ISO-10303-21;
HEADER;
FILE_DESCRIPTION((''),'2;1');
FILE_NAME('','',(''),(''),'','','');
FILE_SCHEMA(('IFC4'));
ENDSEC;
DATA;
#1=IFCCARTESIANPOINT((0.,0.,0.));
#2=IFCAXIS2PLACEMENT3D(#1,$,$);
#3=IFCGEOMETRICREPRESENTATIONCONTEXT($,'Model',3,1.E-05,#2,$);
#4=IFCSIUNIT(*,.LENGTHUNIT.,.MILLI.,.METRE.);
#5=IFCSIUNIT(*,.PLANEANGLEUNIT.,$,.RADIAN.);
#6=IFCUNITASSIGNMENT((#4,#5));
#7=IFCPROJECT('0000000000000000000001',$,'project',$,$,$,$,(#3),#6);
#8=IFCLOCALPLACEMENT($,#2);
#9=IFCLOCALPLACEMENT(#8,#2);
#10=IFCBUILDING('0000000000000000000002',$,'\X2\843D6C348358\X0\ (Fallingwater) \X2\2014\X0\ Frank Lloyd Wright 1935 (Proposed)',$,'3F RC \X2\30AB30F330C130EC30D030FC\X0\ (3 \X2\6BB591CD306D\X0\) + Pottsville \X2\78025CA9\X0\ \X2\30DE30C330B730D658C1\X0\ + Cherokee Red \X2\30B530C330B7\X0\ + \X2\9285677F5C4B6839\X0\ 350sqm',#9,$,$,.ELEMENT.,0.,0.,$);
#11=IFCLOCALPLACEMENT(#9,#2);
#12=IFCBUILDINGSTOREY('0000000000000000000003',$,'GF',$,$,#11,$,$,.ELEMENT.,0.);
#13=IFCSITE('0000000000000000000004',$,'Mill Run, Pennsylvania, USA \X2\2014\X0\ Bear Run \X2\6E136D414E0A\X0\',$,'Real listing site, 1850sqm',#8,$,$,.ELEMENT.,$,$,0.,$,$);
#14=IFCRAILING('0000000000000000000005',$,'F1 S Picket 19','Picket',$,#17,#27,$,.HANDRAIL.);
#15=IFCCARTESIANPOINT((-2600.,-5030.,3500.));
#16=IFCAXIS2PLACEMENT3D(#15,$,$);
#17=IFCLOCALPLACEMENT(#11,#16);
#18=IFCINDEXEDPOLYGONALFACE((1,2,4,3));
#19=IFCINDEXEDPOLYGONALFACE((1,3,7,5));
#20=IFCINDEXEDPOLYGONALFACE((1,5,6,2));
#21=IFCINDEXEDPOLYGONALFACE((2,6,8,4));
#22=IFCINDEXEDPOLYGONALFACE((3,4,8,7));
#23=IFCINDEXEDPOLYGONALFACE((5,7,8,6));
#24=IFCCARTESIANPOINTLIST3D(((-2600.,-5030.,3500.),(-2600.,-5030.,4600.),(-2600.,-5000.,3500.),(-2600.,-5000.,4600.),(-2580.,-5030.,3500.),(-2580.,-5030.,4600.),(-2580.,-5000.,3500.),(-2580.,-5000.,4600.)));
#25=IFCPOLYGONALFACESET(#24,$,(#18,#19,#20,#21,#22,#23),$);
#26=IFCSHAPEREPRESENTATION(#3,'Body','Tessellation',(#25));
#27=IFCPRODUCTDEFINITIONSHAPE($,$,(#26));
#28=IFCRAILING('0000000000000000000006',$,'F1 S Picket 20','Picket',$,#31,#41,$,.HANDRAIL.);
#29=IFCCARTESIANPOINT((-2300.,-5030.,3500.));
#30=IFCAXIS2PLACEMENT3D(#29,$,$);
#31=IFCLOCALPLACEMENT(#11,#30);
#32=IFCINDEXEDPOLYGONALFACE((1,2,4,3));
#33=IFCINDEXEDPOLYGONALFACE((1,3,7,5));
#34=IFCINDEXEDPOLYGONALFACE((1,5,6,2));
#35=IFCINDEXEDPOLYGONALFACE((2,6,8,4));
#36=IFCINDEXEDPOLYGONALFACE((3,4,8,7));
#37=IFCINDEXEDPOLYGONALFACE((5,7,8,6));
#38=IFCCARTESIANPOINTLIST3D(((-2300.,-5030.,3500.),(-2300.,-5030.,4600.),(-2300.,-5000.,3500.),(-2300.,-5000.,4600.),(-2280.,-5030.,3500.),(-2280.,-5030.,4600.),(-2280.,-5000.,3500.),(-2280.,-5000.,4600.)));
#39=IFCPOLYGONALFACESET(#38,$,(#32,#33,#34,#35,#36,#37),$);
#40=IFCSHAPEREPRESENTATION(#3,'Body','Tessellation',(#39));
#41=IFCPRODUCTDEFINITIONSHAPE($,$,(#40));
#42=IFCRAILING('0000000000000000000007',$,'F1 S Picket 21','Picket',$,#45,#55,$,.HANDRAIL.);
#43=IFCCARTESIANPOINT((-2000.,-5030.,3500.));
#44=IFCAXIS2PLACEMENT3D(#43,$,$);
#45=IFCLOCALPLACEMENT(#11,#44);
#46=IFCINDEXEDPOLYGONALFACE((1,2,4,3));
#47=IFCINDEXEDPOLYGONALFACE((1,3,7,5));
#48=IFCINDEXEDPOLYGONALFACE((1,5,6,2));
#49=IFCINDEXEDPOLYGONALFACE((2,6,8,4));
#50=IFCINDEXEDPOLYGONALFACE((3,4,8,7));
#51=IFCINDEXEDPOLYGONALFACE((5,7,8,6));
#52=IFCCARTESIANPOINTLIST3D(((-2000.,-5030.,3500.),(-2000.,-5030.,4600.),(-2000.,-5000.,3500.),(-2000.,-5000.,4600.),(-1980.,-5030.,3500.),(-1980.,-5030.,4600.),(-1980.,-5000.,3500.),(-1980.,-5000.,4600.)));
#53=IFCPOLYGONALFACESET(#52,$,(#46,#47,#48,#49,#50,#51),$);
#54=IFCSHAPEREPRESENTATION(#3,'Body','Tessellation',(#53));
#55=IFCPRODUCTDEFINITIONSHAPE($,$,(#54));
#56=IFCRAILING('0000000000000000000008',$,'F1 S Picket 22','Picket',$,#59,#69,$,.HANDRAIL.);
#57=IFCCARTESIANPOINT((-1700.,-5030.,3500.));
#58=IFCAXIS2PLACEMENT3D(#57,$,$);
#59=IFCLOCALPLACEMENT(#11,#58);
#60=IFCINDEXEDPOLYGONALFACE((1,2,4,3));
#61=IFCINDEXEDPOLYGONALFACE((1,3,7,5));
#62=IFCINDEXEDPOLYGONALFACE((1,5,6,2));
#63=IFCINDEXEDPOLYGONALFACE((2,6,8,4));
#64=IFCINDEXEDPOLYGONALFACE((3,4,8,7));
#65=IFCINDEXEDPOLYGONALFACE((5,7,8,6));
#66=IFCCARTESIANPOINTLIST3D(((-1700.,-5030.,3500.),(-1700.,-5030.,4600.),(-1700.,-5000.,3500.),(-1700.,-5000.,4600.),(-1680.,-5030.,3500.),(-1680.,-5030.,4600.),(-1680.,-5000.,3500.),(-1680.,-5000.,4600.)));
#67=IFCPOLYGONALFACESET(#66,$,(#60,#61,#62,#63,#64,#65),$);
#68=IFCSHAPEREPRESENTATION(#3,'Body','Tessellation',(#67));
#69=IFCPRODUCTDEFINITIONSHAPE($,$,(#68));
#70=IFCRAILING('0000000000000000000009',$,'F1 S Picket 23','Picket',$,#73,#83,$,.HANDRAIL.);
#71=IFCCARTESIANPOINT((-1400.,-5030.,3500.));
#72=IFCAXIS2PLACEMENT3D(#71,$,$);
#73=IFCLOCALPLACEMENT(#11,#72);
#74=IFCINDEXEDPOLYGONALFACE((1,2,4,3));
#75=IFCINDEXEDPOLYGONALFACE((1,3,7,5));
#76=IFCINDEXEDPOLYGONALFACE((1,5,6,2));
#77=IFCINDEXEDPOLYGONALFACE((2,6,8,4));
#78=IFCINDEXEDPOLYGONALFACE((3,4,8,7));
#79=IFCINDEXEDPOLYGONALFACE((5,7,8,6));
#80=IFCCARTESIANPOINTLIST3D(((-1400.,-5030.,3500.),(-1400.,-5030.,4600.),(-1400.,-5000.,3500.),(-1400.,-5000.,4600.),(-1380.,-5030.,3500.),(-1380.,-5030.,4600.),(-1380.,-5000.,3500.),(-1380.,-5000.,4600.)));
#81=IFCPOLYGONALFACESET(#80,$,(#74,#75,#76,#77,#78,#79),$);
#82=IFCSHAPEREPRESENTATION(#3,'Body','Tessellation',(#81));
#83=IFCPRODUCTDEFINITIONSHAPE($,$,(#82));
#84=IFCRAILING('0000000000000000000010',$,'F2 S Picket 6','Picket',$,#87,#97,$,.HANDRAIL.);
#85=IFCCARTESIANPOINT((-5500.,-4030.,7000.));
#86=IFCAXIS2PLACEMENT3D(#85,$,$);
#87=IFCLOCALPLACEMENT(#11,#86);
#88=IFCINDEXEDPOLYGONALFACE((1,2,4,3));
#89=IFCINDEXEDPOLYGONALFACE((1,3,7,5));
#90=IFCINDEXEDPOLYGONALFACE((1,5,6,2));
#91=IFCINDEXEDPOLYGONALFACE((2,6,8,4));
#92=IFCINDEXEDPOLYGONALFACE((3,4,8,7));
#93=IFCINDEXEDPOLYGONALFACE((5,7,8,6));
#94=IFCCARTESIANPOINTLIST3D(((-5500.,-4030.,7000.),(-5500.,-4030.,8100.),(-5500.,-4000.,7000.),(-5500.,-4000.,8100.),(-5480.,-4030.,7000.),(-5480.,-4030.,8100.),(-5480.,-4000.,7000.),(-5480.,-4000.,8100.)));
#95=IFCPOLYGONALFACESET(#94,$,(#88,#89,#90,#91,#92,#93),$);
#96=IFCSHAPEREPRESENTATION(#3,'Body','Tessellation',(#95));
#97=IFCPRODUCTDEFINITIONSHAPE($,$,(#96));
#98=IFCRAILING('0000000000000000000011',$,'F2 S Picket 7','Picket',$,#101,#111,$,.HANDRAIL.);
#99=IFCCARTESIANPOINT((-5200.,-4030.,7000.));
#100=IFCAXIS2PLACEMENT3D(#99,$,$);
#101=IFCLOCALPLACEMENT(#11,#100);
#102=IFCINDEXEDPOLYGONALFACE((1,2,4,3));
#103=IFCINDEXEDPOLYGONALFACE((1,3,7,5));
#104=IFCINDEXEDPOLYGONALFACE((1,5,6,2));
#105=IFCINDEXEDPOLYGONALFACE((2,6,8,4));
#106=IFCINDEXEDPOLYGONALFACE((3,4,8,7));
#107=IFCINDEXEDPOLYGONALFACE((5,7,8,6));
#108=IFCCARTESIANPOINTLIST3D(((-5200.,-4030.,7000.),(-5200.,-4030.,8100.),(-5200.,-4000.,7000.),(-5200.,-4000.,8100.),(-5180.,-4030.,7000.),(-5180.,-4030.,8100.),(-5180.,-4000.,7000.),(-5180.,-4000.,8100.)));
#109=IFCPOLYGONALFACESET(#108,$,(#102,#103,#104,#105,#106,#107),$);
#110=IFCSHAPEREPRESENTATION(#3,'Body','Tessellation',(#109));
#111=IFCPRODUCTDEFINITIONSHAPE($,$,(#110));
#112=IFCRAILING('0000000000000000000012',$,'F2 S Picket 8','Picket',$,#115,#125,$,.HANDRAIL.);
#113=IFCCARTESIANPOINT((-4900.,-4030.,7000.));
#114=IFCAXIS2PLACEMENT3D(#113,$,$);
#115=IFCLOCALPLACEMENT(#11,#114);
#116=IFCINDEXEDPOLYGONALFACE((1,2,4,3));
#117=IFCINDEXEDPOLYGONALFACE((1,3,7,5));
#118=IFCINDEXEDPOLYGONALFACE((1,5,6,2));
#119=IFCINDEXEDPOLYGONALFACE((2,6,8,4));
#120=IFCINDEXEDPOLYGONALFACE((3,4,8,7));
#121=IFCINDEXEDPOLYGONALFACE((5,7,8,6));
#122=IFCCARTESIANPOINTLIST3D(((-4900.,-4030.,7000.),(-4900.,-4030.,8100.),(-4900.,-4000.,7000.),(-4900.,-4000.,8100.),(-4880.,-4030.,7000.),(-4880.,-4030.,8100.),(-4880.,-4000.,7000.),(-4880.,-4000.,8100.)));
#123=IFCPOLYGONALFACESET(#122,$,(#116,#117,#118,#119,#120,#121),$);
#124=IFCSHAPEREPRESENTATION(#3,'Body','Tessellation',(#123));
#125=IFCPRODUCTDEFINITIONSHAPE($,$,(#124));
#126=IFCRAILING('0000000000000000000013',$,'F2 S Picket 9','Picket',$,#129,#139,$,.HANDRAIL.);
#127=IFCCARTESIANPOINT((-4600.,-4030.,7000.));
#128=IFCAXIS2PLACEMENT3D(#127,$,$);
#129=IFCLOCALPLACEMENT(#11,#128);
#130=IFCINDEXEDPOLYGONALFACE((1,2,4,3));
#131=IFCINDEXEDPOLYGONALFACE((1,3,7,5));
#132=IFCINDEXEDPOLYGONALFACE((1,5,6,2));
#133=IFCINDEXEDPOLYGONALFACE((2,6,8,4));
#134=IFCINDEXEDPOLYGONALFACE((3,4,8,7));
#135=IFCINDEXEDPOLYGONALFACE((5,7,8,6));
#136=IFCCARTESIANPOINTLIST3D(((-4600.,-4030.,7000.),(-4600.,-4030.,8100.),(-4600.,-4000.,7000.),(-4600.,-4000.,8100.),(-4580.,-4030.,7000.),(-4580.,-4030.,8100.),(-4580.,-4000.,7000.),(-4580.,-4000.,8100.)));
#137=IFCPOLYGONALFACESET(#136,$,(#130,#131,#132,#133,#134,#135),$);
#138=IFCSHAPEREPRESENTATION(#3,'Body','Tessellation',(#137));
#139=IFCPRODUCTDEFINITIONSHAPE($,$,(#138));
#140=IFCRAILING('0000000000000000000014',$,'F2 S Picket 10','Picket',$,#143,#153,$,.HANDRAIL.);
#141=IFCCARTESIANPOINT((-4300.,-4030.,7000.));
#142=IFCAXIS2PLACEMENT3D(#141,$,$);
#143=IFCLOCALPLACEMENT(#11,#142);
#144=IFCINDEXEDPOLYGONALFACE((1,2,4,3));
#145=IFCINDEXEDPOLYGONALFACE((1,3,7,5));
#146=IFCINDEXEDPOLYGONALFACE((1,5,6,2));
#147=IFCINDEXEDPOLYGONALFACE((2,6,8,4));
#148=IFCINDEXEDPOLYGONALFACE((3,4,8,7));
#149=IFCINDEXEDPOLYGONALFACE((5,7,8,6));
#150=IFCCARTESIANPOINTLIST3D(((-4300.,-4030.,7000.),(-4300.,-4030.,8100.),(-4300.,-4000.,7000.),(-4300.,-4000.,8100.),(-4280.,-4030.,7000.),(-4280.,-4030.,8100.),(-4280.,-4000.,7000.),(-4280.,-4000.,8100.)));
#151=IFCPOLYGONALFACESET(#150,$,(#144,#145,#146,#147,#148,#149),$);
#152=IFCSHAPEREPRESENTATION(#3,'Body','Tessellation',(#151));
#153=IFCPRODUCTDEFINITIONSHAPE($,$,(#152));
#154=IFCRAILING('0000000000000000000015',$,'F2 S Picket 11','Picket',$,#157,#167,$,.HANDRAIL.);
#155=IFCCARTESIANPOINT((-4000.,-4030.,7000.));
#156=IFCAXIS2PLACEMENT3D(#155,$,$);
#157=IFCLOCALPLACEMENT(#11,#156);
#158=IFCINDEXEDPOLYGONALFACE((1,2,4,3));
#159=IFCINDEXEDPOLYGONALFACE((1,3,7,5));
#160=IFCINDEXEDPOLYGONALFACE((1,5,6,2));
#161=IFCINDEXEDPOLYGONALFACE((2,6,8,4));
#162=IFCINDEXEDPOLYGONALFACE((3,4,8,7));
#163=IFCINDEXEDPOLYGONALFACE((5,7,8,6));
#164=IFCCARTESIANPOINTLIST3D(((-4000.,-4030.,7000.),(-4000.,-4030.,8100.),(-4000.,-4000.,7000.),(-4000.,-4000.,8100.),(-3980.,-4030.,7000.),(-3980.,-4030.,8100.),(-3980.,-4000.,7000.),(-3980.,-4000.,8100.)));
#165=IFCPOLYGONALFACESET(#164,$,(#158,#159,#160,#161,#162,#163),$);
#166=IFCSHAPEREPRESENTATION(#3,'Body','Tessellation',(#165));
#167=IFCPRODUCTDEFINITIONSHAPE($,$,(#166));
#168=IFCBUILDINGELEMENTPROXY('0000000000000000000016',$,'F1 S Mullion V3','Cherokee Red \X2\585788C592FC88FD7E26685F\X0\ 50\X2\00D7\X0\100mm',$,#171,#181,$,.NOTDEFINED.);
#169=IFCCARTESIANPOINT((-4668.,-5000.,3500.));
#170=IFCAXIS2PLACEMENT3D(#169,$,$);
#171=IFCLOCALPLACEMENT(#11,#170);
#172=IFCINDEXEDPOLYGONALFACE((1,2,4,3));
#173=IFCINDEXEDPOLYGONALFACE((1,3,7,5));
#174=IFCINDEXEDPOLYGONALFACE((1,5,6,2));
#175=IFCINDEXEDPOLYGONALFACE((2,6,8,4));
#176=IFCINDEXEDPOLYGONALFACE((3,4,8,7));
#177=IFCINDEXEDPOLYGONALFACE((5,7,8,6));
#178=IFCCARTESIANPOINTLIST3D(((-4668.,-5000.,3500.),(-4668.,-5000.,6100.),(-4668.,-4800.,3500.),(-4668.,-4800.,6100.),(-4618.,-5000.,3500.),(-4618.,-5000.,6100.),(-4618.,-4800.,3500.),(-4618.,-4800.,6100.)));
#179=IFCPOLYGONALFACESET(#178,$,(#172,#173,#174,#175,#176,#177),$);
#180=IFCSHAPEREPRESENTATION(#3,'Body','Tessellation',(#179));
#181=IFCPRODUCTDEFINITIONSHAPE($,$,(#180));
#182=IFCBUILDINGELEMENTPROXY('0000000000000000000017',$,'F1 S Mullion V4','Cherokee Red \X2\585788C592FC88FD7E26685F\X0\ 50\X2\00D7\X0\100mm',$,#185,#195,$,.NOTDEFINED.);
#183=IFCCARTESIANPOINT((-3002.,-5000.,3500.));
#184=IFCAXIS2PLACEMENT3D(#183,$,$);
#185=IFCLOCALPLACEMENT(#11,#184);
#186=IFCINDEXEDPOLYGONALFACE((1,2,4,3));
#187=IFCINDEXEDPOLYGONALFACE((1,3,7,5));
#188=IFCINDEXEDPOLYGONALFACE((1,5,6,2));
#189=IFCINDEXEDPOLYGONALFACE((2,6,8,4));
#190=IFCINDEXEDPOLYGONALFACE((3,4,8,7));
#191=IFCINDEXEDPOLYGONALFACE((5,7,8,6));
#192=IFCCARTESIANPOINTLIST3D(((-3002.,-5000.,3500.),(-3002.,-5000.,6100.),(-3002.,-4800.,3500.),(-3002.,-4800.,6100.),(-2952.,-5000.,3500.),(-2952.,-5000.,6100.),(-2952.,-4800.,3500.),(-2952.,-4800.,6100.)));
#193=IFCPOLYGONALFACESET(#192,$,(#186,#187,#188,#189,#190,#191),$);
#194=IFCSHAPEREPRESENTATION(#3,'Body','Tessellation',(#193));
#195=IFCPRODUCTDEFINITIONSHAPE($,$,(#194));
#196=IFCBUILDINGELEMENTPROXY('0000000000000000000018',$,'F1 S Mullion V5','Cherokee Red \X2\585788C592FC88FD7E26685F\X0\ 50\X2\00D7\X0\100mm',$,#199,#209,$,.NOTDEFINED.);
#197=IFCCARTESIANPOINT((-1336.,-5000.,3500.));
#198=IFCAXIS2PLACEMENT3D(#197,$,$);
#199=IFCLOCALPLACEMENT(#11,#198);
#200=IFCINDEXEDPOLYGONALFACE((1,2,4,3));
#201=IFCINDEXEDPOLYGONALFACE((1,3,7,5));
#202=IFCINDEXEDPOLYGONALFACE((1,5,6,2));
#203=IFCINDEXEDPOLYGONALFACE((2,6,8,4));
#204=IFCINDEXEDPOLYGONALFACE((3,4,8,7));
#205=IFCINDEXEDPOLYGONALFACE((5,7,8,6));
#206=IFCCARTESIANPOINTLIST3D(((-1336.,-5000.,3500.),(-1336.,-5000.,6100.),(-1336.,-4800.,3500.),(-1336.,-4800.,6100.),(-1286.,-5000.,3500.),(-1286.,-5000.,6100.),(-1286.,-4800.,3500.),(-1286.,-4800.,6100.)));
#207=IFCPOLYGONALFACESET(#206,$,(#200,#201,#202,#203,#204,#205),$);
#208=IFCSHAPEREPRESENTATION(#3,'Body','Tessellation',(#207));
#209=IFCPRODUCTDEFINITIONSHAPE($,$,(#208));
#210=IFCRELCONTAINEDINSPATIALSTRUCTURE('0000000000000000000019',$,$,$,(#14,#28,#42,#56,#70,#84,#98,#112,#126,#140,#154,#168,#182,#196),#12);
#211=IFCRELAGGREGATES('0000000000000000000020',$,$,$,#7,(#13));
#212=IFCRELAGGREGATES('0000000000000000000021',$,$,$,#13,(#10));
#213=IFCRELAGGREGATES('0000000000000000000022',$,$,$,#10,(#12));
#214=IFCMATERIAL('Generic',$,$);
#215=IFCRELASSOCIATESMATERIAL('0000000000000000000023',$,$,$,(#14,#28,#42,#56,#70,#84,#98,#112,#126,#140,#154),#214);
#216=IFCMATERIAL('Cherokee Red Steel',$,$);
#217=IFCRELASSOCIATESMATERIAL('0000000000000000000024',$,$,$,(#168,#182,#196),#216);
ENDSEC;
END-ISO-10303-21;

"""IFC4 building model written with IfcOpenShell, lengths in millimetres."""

from ifc_helpers import new_model, si_unit, frame, frame_2d, origin, place, context, project, spatial, rectangle, extrude, material, element, save


model = new_model("IFC4")

# Units and contexts
model_context = context("Model", 3, precision=1e-05, world=origin())
ifc_project = project(units=[si_unit("LENGTHUNIT", "METRE", prefix="MILLI"), si_unit("PLANEANGLEUNIT", "RADIAN")], contexts=[model_context])

# Site, building, storey
site_placement = place(None, origin())
site = spatial("IfcSite", under=ifc_project, at=site_placement, Name="Mill Run, Pennsylvania, USA — Bear Run 渓流上", ObjectType="Real listing site, 1850sqm", CompositionType="ELEMENT", RefElevation=0.0)
building_placement = place(site_placement, origin())
building = spatial("IfcBuilding", under=site, at=building_placement, Name="落水荘 (Fallingwater) — Frank Lloyd Wright 1935 (Proposed)", ObjectType="3F RC カンチレバー (3 段重ね) + Pottsville 砂岩 マッシブ壁 + Cherokee Red サッシ + 銅板屋根 350sqm", CompositionType="ELEMENT", ElevationOfRefHeight=0.0, ElevationOfTerrain=0.0)
storey_placement = place(building_placement, origin())
storey = spatial("IfcBuildingStorey", under=building, at=storey_placement, Name="GF", CompositionType="ELEMENT", Elevation=0.0)

# Shared definitions
ifc_material_1 = material(Name="Cherokee Red Steel")

# Railings
ifc_material_2 = material(Name="Generic")
railing_1_placement = place(storey_placement, frame((-2600.0, -5030.0, 3500.0)))
element("IfcRailing", 1, at=railing_1_placement, inside=storey, material=ifc_material_2, Name="F1 S Picket 19", Description="Picket", PredefinedType="HANDRAIL", context=model_context, shape_type="SweptSolid", body=[
    extrude(rectangle(XDim=20.0, YDim=30.0, at=frame_2d((10.0, 15.0))), frame((-2600.0, -5030.0, 3500.0)), (0.0, 0.0, 1.0), 1100.0),
])
railing_2_placement = place(storey_placement, frame((-2300.0, -5030.0, 3500.0)))
element("IfcRailing", 2, at=railing_2_placement, inside=storey, material=ifc_material_2, Name="F1 S Picket 20", Description="Picket", PredefinedType="HANDRAIL", context=model_context, shape_type="SweptSolid", body=[
    extrude(rectangle(XDim=20.0, YDim=30.0, at=frame_2d((10.0, 15.0))), frame((-2300.0, -5030.0, 3500.0)), (0.0, 0.0, 1.0), 1100.0),
])
railing_3_placement = place(storey_placement, frame((-2000.0, -5030.0, 3500.0)))
element("IfcRailing", 3, at=railing_3_placement, inside=storey, material=ifc_material_2, Name="F1 S Picket 21", Description="Picket", PredefinedType="HANDRAIL", context=model_context, shape_type="SweptSolid", body=[
    extrude(rectangle(XDim=20.0, YDim=30.0, at=frame_2d((10.0, 15.0))), frame((-2000.0, -5030.0, 3500.0)), (0.0, 0.0, 1.0), 1100.0),
])
railing_4_placement = place(storey_placement, frame((-1700.0, -5030.0, 3500.0)))
element("IfcRailing", 4, at=railing_4_placement, inside=storey, material=ifc_material_2, Name="F1 S Picket 22", Description="Picket", PredefinedType="HANDRAIL", context=model_context, shape_type="SweptSolid", body=[
    extrude(rectangle(XDim=20.0, YDim=30.0, at=frame_2d((10.0, 15.0))), frame((-1700.0, -5030.0, 3500.0)), (0.0, 0.0, 1.0), 1100.0),
])
railing_5_placement = place(storey_placement, frame((-1400.0, -5030.0, 3500.0)))
element("IfcRailing", 5, at=railing_5_placement, inside=storey, material=ifc_material_2, Name="F1 S Picket 23", Description="Picket", PredefinedType="HANDRAIL", context=model_context, shape_type="SweptSolid", body=[
    extrude(rectangle(XDim=20.0, YDim=30.0, at=frame_2d((10.0, 15.0))), frame((-1400.0, -5030.0, 3500.0)), (0.0, 0.0, 1.0), 1100.0),
])
railing_6_placement = place(storey_placement, frame((-5500.0, -4030.0, 7000.0)))
element("IfcRailing", 6, at=railing_6_placement, inside=storey, material=ifc_material_2, Name="F2 S Picket 6", Description="Picket", PredefinedType="HANDRAIL", context=model_context, shape_type="SweptSolid", body=[
    extrude(rectangle(XDim=20.0, YDim=30.0, at=frame_2d((10.0, 15.0))), frame((-5500.0, -4030.0, 7000.0)), (0.0, 0.0, 1.0), 1100.0),
])
railing_7_placement = place(storey_placement, frame((-5200.0, -4030.0, 7000.0)))
element("IfcRailing", 7, at=railing_7_placement, inside=storey, material=ifc_material_2, Name="F2 S Picket 7", Description="Picket", PredefinedType="HANDRAIL", context=model_context, shape_type="SweptSolid", body=[
    extrude(rectangle(XDim=20.0, YDim=30.0, at=frame_2d((10.0, 15.0))), frame((-5200.0, -4030.0, 7000.0)), (0.0, 0.0, 1.0), 1100.0),
])
railing_8_placement = place(storey_placement, frame((-4900.0, -4030.0, 7000.0)))
element("IfcRailing", 8, at=railing_8_placement, inside=storey, material=ifc_material_2, Name="F2 S Picket 8", Description="Picket", PredefinedType="HANDRAIL", context=model_context, shape_type="SweptSolid", body=[
    extrude(rectangle(XDim=20.0, YDim=30.0, at=frame_2d((10.0, 15.0))), frame((-4900.0, -4030.0, 7000.0)), (0.0, 0.0, 1.0), 1100.0),
])
railing_9_placement = place(storey_placement, frame((-4600.0, -4030.0, 7000.0)))
element("IfcRailing", 9, at=railing_9_placement, inside=storey, material=ifc_material_2, Name="F2 S Picket 9", Description="Picket", PredefinedType="HANDRAIL", context=model_context, shape_type="SweptSolid", body=[
    extrude(rectangle(XDim=20.0, YDim=30.0, at=frame_2d((10.0, 15.0))), frame((-4600.0, -4030.0, 7000.0)), (0.0, 0.0, 1.0), 1100.0),
])
railing_10_placement = place(storey_placement, frame((-4300.0, -4030.0, 7000.0)))
element("IfcRailing", 10, at=railing_10_placement, inside=storey, material=ifc_material_2, Name="F2 S Picket 10", Description="Picket", PredefinedType="HANDRAIL", context=model_context, shape_type="SweptSolid", body=[
    extrude(rectangle(XDim=20.0, YDim=30.0, at=frame_2d((10.0, 15.0))), frame((-4300.0, -4030.0, 7000.0)), (0.0, 0.0, 1.0), 1100.0),
])
railing_11_placement = place(storey_placement, frame((-4000.0, -4030.0, 7000.0)))
element("IfcRailing", 11, at=railing_11_placement, inside=storey, material=ifc_material_2, Name="F2 S Picket 11", Description="Picket", PredefinedType="HANDRAIL", context=model_context, shape_type="SweptSolid", body=[
    extrude(rectangle(XDim=20.0, YDim=30.0, at=frame_2d((10.0, 15.0))), frame((-4000.0, -4030.0, 7000.0)), (0.0, 0.0, 1.0), 1100.0),
])

# Building element proxies
proxy_1_placement = place(storey_placement, frame((-4668.0, -5000.0, 3500.0)))
element("IfcBuildingElementProxy", 12, at=proxy_1_placement, inside=storey, material=ifc_material_1, Name="F1 S Mullion V3", Description="Cherokee Red 塗装鋼製縦桟 50×100mm", PredefinedType="NOTDEFINED", context=model_context, shape_type="SweptSolid", body=[
    extrude(rectangle(XDim=50.0, YDim=200.0, at=frame_2d((25.0, 100.0))), frame((-4668.0, -5000.0, 3500.0)), (0.0, 0.0, 1.0), 2600.0),
])
proxy_2_placement = place(storey_placement, frame((-3002.0, -5000.0, 3500.0)))
element("IfcBuildingElementProxy", 13, at=proxy_2_placement, inside=storey, material=ifc_material_1, Name="F1 S Mullion V4", Description="Cherokee Red 塗装鋼製縦桟 50×100mm", PredefinedType="NOTDEFINED", context=model_context, shape_type="SweptSolid", body=[
    extrude(rectangle(XDim=50.0, YDim=200.0, at=frame_2d((25.0, 100.0))), frame((-3002.0, -5000.0, 3500.0)), (0.0, 0.0, 1.0), 2600.0),
])
proxy_3_placement = place(storey_placement, frame((-1336.0, -5000.0, 3500.0)))
element("IfcBuildingElementProxy", 14, at=proxy_3_placement, inside=storey, material=ifc_material_1, Name="F1 S Mullion V5", Description="Cherokee Red 塗装鋼製縦桟 50×100mm", PredefinedType="NOTDEFINED", context=model_context, shape_type="SweptSolid", body=[
    extrude(rectangle(XDim=50.0, YDim=200.0, at=frame_2d((25.0, 100.0))), frame((-1336.0, -5000.0, 3500.0)), (0.0, 0.0, 1.0), 2600.0),
])

save(model, "model.ifc")
